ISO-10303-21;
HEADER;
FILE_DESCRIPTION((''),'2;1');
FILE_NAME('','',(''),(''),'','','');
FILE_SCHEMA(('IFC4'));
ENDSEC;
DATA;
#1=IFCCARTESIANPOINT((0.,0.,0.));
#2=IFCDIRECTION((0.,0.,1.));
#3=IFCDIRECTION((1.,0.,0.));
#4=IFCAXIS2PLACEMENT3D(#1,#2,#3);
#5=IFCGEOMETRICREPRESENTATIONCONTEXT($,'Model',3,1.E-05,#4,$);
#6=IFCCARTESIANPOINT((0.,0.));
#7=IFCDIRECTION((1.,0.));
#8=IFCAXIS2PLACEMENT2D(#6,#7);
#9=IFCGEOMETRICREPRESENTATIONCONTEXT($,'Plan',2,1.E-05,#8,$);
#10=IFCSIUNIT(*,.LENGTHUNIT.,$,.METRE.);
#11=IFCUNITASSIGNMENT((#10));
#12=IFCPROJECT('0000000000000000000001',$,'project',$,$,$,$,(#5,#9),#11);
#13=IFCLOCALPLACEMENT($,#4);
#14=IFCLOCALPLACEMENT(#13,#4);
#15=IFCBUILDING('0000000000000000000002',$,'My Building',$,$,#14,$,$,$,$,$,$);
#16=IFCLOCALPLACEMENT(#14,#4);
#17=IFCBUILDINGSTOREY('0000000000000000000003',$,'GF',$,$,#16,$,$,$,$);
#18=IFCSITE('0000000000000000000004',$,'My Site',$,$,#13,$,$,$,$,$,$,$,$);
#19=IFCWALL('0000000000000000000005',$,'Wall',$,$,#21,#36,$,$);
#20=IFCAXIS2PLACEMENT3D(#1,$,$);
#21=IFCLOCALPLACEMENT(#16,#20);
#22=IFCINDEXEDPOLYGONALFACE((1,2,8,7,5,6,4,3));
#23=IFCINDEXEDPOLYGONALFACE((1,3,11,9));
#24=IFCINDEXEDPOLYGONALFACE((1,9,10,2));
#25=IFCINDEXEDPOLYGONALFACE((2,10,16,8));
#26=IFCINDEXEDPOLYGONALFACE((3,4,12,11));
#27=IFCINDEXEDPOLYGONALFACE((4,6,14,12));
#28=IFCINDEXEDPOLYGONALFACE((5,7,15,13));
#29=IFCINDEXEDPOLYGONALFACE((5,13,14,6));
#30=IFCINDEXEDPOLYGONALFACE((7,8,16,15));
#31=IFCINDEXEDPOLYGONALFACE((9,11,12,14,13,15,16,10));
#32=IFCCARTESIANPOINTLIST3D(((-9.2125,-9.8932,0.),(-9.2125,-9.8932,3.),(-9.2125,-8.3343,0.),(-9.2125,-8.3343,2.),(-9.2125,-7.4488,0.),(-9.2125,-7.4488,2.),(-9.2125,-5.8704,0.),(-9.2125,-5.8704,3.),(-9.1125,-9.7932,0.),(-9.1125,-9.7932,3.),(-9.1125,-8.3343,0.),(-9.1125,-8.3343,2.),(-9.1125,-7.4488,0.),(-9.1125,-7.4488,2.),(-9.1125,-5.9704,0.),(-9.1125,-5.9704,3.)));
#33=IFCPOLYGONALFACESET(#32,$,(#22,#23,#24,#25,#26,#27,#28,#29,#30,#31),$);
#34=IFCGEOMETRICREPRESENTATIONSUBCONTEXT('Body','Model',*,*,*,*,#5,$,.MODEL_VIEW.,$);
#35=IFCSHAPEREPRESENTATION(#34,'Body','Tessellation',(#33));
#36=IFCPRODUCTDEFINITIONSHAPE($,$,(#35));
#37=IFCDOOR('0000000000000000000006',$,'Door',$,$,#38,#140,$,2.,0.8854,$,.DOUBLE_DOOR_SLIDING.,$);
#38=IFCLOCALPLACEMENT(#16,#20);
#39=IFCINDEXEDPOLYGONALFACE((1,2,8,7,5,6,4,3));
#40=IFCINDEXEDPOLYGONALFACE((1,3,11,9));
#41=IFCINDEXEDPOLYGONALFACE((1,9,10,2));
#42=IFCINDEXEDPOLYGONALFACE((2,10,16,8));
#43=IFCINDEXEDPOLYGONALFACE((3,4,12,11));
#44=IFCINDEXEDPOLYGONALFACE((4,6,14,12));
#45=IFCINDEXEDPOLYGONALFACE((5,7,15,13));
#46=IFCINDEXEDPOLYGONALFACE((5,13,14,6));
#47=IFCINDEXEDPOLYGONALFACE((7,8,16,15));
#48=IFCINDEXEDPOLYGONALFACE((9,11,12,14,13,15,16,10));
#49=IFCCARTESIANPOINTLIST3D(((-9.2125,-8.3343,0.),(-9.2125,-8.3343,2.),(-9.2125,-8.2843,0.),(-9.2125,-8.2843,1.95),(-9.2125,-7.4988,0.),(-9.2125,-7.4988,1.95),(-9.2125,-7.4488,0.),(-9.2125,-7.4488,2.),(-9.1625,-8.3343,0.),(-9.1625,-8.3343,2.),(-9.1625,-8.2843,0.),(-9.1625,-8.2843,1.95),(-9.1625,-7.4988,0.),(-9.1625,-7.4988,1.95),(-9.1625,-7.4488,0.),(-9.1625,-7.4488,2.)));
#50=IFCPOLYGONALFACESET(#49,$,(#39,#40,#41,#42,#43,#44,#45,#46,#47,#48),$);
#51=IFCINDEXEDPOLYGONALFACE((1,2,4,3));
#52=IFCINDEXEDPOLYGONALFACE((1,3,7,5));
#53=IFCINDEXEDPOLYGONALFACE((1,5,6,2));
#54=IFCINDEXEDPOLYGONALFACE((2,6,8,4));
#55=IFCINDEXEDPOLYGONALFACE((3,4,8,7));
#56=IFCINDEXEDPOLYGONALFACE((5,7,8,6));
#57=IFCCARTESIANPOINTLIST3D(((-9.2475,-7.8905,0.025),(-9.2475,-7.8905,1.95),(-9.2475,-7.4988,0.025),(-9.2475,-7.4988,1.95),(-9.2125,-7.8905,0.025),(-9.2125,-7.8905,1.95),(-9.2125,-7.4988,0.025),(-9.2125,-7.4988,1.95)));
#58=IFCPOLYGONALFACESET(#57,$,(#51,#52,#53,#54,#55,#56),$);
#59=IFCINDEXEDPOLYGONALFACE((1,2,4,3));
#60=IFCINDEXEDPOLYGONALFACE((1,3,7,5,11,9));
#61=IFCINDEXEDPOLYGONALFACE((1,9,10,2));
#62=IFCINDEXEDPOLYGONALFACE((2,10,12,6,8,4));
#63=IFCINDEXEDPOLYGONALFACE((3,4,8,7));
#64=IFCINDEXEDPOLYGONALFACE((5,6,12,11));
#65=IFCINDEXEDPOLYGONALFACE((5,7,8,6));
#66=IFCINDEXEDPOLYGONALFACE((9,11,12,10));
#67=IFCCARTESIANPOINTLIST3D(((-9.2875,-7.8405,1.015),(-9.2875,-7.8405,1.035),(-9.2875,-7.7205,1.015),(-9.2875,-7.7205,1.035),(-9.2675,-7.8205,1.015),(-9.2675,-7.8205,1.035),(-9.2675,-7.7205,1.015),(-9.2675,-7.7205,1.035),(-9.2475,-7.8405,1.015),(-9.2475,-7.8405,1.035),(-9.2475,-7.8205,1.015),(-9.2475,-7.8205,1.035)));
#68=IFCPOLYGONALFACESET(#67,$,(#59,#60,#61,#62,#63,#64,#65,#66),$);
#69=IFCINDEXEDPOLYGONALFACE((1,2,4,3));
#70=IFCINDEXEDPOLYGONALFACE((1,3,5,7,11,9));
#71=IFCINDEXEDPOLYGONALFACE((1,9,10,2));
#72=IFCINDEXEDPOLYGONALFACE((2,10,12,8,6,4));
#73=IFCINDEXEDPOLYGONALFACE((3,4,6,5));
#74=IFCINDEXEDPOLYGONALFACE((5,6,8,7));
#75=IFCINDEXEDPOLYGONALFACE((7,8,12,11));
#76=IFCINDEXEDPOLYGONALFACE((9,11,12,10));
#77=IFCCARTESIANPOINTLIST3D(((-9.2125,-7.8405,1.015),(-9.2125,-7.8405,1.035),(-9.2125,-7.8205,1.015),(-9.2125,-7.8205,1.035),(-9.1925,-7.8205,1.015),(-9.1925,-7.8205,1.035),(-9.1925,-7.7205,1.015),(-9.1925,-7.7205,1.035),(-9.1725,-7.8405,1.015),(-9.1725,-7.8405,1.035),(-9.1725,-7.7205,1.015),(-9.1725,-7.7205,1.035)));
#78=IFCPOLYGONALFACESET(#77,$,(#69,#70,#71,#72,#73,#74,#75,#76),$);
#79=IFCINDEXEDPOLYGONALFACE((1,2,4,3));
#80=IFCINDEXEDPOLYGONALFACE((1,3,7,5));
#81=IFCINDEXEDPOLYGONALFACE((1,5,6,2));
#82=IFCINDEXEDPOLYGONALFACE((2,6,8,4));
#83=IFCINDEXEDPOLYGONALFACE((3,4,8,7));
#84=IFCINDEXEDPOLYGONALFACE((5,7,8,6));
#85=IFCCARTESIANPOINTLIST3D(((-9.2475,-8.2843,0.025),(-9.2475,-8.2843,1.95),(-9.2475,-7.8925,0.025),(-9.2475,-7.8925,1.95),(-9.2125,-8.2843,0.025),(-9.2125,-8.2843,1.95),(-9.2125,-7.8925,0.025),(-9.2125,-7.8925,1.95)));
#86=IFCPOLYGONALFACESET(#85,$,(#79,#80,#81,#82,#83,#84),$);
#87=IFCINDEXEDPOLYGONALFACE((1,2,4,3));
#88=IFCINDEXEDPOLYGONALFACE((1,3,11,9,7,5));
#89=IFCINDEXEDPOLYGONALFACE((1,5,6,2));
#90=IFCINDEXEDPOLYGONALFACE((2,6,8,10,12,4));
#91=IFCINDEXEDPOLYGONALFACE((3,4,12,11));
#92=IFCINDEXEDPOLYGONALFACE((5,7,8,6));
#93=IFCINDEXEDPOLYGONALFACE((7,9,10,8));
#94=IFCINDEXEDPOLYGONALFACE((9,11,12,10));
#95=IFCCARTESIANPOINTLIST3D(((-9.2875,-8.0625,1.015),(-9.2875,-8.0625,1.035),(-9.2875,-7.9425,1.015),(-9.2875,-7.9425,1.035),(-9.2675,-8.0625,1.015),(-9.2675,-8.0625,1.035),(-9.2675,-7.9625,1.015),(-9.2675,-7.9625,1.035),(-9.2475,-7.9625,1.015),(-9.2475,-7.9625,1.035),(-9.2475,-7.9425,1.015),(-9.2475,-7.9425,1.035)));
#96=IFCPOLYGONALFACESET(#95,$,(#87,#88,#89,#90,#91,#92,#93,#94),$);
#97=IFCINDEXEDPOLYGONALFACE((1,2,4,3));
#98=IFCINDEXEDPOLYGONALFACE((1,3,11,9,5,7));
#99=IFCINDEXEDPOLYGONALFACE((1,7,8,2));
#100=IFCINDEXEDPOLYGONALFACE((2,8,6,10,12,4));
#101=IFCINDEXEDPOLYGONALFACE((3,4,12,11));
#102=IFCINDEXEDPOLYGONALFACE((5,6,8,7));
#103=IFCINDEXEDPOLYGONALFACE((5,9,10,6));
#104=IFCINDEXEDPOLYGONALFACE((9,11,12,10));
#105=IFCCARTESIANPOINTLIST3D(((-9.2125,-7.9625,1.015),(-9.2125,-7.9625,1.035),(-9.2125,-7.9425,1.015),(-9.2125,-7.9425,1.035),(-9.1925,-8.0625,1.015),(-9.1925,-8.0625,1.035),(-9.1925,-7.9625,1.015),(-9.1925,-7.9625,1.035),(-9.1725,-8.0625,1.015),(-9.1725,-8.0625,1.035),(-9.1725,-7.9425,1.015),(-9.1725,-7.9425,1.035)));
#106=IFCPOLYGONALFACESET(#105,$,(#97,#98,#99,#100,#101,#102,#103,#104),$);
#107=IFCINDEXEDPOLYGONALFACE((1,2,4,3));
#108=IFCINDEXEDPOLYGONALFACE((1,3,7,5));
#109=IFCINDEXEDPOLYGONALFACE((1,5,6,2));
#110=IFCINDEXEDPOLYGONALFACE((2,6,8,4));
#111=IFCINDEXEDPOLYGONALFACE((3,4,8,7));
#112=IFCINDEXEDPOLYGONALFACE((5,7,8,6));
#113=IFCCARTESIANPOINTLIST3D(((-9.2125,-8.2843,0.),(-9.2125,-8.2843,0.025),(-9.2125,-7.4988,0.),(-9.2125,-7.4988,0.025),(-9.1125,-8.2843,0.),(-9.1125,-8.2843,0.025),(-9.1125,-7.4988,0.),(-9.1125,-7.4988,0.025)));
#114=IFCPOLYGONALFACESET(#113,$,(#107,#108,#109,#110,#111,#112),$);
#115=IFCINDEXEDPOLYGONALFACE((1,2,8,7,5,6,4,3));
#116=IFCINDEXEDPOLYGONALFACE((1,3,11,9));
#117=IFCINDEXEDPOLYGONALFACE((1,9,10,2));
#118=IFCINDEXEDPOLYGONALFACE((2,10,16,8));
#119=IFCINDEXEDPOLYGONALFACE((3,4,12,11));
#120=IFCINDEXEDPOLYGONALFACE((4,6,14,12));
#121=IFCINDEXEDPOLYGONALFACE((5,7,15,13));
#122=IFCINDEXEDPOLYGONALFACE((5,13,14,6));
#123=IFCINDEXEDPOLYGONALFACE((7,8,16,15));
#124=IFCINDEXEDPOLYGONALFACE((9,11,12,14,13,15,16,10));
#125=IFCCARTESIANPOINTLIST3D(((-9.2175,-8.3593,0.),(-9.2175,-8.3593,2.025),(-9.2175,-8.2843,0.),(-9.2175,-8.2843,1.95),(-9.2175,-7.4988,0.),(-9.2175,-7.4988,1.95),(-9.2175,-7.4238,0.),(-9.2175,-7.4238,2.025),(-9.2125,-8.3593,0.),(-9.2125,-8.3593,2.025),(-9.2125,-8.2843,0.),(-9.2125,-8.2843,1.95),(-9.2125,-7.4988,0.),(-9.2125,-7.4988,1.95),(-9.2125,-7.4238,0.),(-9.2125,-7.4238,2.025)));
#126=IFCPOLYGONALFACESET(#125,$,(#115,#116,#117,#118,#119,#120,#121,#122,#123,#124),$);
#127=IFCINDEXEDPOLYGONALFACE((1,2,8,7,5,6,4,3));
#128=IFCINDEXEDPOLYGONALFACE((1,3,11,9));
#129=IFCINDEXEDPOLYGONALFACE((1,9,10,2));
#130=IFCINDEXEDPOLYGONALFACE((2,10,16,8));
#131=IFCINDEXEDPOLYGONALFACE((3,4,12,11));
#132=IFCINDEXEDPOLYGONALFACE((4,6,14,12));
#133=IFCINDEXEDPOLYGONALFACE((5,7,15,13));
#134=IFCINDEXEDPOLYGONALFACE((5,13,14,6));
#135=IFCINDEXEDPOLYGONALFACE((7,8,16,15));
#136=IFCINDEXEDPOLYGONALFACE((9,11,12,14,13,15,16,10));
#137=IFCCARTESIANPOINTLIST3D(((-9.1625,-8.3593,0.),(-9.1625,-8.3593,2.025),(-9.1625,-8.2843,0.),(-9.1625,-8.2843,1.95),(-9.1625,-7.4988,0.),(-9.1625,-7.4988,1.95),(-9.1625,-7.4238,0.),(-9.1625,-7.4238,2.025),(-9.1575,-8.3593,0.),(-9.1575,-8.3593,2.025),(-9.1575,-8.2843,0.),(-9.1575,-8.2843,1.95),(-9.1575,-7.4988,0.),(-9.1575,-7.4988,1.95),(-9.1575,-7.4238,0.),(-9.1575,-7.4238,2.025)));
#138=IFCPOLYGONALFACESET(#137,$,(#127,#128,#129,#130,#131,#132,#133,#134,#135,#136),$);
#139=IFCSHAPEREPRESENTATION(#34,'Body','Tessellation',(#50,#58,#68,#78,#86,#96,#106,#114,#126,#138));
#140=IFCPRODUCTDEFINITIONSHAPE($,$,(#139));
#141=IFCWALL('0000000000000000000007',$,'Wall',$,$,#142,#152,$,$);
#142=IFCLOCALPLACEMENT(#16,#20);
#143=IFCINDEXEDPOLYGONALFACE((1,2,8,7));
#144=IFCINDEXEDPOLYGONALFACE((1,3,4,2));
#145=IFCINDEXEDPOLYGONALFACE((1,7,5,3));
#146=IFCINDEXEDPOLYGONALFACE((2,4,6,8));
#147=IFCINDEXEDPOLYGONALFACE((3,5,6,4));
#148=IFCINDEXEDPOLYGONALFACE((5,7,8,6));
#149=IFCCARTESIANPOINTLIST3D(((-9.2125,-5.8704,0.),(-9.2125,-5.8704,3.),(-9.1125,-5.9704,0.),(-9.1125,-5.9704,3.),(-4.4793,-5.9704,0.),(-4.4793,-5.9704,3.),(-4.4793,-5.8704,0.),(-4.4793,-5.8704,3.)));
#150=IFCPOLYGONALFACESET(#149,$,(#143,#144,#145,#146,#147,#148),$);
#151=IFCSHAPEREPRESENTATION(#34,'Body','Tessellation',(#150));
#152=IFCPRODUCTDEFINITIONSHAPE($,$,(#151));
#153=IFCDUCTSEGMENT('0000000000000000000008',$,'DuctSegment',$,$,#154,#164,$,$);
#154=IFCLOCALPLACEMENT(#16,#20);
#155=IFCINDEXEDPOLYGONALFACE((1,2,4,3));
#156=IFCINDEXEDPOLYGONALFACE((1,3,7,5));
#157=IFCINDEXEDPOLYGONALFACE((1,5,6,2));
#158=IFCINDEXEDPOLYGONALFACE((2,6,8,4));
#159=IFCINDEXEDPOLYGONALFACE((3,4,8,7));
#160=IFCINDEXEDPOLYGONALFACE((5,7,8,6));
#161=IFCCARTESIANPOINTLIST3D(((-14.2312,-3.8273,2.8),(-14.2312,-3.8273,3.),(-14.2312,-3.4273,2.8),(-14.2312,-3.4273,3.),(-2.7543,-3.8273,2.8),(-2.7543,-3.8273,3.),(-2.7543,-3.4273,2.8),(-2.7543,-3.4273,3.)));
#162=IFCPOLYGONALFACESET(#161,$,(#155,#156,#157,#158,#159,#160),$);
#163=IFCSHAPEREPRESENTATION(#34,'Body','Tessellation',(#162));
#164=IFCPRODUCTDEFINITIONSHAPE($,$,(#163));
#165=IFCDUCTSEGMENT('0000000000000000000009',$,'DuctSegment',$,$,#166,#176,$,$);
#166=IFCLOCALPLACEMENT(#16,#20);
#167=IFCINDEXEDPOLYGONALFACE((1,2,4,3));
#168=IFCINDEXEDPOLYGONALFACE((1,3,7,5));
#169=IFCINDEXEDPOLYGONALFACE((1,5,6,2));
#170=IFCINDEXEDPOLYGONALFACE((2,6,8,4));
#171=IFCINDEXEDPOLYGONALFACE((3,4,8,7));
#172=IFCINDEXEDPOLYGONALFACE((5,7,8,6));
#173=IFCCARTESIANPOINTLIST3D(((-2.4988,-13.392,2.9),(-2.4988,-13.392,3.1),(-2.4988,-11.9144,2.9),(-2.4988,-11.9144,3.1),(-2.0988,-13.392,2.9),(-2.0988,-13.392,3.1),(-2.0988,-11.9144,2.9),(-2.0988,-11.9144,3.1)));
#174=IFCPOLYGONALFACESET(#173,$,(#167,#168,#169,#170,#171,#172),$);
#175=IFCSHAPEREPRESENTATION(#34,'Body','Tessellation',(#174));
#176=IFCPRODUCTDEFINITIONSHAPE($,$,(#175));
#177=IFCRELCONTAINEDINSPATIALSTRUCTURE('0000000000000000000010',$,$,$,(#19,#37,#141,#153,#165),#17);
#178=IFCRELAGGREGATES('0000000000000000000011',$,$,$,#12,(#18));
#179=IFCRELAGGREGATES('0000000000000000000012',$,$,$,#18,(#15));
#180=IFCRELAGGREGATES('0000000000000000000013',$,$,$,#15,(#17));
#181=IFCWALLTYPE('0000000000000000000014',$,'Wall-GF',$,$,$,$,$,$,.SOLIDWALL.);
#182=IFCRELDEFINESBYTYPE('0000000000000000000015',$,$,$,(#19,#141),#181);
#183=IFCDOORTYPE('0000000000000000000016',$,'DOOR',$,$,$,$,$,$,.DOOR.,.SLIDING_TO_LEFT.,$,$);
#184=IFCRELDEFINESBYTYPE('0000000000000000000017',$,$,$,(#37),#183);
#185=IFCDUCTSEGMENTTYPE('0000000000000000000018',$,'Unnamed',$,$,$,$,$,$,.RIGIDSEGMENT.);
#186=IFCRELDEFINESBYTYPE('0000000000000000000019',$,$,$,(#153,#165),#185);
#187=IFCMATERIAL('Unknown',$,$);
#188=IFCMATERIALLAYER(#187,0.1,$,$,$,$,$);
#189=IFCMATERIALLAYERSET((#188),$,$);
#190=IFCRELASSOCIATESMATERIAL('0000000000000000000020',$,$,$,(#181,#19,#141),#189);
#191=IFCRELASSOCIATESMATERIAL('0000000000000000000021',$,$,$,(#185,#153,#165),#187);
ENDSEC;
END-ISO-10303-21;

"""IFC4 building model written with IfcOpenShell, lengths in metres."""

from ifc_helpers import new_model, entity, si_unit, frame, origin_with_axes, origin_2d_with_axis, place, context, subcontext, project, spatial, line, indexed_curve, rectangle, outline, extrude, shape, source, transform, mapped, material, layer, layer_set, layer_usage, material_profile, profile_set, profile_usage, type_object, type_shapes, element, fill, save


model = new_model("IFC4")

# Units and contexts
model_context = context("Model", 3, precision=1e-05, world=origin_with_axes())
plan_context = context("Plan", 2, precision=1e-05, world=origin_2d_with_axis())
body_context_1 = subcontext(model_context, "Body", "Model", "MODEL_VIEW")
body_context_2 = subcontext(plan_context, "Body", "Plan", "PLAN_VIEW")
ifc_project = project(units=[si_unit("LENGTHUNIT", "METRE")], contexts=[model_context, plan_context])

# Site, building, storey
site_placement = place(None, origin_with_axes())
site = spatial("IfcSite", under=ifc_project, at=site_placement, Name="My Site")
building_placement = place(site_placement, origin_with_axes())
building = spatial("IfcBuilding", under=site, at=building_placement, Name="My Building")
storey_placement = place(building_placement, origin_with_axes())
storey = spatial("IfcBuildingStorey", under=building, at=storey_placement, Name="GF")

# Shared definitions
ifc_material = material(Name="Unknown")

# Shared definitions
ifc_layer_1 = layer(ifc_material, 0.1)
ifc_layer_set_1 = layer_set([ifc_layer_1])
wall_type = type_object("IfcWallType", Name="Wall-GF", PredefinedType="SOLIDWALL", material=ifc_layer_set_1)
shared_shape_1 = source(origin_with_axes(), body_context_1, "Body", "SweptSolid", [
    extrude(outline(indexed_curve([(0.0, 0.0), (0.8854, 0.0), (0.8854, 2.0), (0.0, 2.0)], segments=[line(1, 2, 3, 4, 1)])), frame((0.0, -0.6, 0.0), z_axis=(0.0, -1.0, 0.0), x_axis=(1.0, 0.0, 0.0)), (0.0, 0.0, -1.0), 1.2),
])
door_type = type_object("IfcDoorType", Name="DOOR", OperationType="SLIDING_TO_LEFT", PredefinedType="DOOR")
shared_shape_2 = source(origin_with_axes(), body_context_1, "Body", "SweptSolid", [
    extrude(outline(indexed_curve([(0.0, 0.0), (0.0, 2.0), (0.8854, 2.0), (0.8854, 0.0), (0.8354, 0.0), (0.8354, 1.95), (0.05, 1.95), (0.05, 0.0)], segments=[line(1, 2, 3, 4, 5, 6, 7, 8, 1)])), frame((0.0, 0.0, 0.0), z_axis=(0.0, -1.0, 0.0), x_axis=(1.0, 0.0, 0.0)), (0.0, 0.0, -1.0), 0.05),
    extrude(outline(indexed_curve([(0.0, 0.0), (0.3917, 0.0), (0.3917, 0.035), (0.0, 0.035)], segments=[line(1, 2, 3, 4, 1)])), frame((0.05, -0.035, 0.025), z_axis=(0.0, 0.0, 1.0), x_axis=(1.0, 0.0, 0.0)), (0.0, 0.0, 1.0), 1.925),
    extrude(outline(indexed_curve([(0.0, 0.0), (0.0, -0.04), (-0.12, -0.04), (-0.12, -0.02), (-0.02, -0.02), (-0.02, 0.0)], segments=[line(1, 2, 3, 4, 5, 6, 1)])), frame((0.3917, -0.035, 1.015), z_axis=(0.0, 0.0, 1.0), x_axis=(1.0, 0.0, 0.0)), (0.0, 0.0, 1.0), 0.02),
    extrude(outline(indexed_curve([(0.0, 0.0), (0.0, 0.04), (-0.12, 0.04), (-0.12, 0.02), (-0.02, 0.02), (-0.02, 0.0)], segments=[line(1, 2, 3, 4, 5, 6, 1)])), frame((0.3917, 0.0, 1.015), z_axis=(0.0, 0.0, 1.0), x_axis=(1.0, 0.0, 0.0)), (0.0, 0.0, 1.0), 0.02),
    extrude(outline(indexed_curve([(0.0, 0.0), (-0.3917, 0.0), (-0.3917, 0.035), (0.0, 0.035)], segments=[line(1, 2, 3, 4, 1)])), frame((0.8354, -0.035, 0.025), z_axis=(0.0, 0.0, 1.0), x_axis=(1.0, 0.0, 0.0)), (0.0, 0.0, 1.0), 1.925),
    extrude(outline(indexed_curve([(0.0, 0.0), (0.0, -0.04), (0.12, -0.04), (0.12, -0.02), (0.02, -0.02), (0.02, 0.0)], segments=[line(1, 2, 3, 4, 5, 6, 1)])), frame((0.4937, -0.035, 1.015), z_axis=(0.0, 0.0, 1.0), x_axis=(1.0, 0.0, 0.0)), (0.0, 0.0, 1.0), 0.02),
    extrude(outline(indexed_curve([(0.0, 0.0), (0.0, 0.04), (0.12, 0.04), (0.12, 0.02), (0.02, 0.02), (0.02, 0.0)], segments=[line(1, 2, 3, 4, 5, 6, 1)])), frame((0.4937, 0.0, 1.015), z_axis=(0.0, 0.0, 1.0), x_axis=(1.0, 0.0, 0.0)), (0.0, 0.0, 1.0), 0.02),
    extrude(outline(indexed_curve([(0.0, 0.0), (0.7854, 0.0), (0.7854, 0.1), (0.0, 0.1)], segments=[line(1, 2, 3, 4, 1)])), frame((0.05, 0.0, 0.0), z_axis=(0.0, 0.0, 1.0), x_axis=(1.0, 0.0, 0.0)), (0.0, 0.0, 1.0), 0.025),
    extrude(outline(indexed_curve([(0.0, 0.0), (0.0, 2.025), (0.9354, 2.025), (0.9354, 0.0), (0.8604, 0.0), (0.8604, 1.95), (0.075, 1.95), (0.075, 0.0)], segments=[line(1, 2, 3, 4, 5, 6, 7, 8, 1)])), frame((-0.025, -0.005, 0.0), z_axis=(0.0, -1.0, 0.0), x_axis=(1.0, 0.0, 0.0)), (0.0, 0.0, -1.0), 0.005),
    extrude(outline(indexed_curve([(0.0, 0.0), (0.0, 2.025), (0.9354, 2.025), (0.9354, 0.0), (0.8604, 0.0), (0.8604, 1.95), (0.075, 1.95), (0.075, 0.0)], segments=[line(1, 2, 3, 4, 5, 6, 7, 8, 1)])), frame((-0.025, 0.05, 0.0), z_axis=(0.0, -1.0, 0.0), x_axis=(1.0, 0.0, 0.0)), (0.0, 0.0, -1.0), 0.005),
])
shared_shape_3 = source(origin_with_axes(), body_context_2, "Body", "Curve2D", [
    entity("IfcIndexedPolyCurve", entity("IfcCartesianPointList2D", [[0.0, 0.0], [0.05, 0.0], [0.05, 0.05], [0.0, 0.05]]), [entity("IfcLineIndex", [1, 2, 3, 4, 1])]),
    entity("IfcIndexedPolyCurve", entity("IfcCartesianPointList2D", [[0.8854, 0.0], [0.8354, 0.0], [0.8354, 0.05], [0.8854, 0.05]]), [entity("IfcLineIndex", [1, 2, 3, 4, 1])]),
    entity("IfcIndexedPolyCurve", entity("IfcCartesianPointList2D", [[-0.1464, -0.035], [0.2464, -0.035], [0.2464, 0.0], [-0.1464, 0.0]]), [entity("IfcLineIndex", [1, 2, 3, 4, 1])]),
    entity("IfcIndexedPolyCurve", entity("IfcCartesianPointList2D", [[1.0318, -0.035], [0.6391, -0.035], [0.6391, 0.0], [1.0318, 0.0]]), [entity("IfcLineIndex", [1, 2, 3, 4, 1])]),
])
type_shapes(door_type, [shared_shape_2, shared_shape_3])

# Wall, opening, door
ifc_layer_usage_1 = layer_usage(ifc_layer_set_1, "AXIS2", "POSITIVE", 0.0)
wall_1_placement = place(storey_placement, frame((-9.1125, -9.7932, 0.0), z_axis=(0.0, 0.0, 1.0), x_axis=(0.0, 1.0, 0.0)))
wall_1 = element("IfcWall", 1, at=wall_1_placement, inside=storey, type_object=wall_type, material=ifc_layer_usage_1, Name="Wall", context=body_context_1, shape_type="SweptSolid", body=[
    extrude(outline(indexed_curve([(0.0, 0.0), (-0.1, 0.1), (3.9228, 0.1), (3.8228, 0.0)], segments=[line(1, 2, 3, 4, 1)])), origin_with_axes(), (0.0, 0.0, 1.0), 3.0),
])
opening_1_placement = place(wall_1_placement, frame((2.3443, 0.1, 0.0), z_axis=(0.0, 0.0, 1.0), x_axis=(-1.0, 0.0, 0.0)))
opening_1 = element("IfcOpeningElement", 2, at=opening_1_placement, cuts=wall_1, PredefinedType="OPENING", context=body_context_1, shape_type="MappedRepresentation", body=[
    mapped(shared_shape_1, transform((0.0, 0.0, 0.0), x_axis=(1.0, 0.0, 0.0), y_axis=(0.0, 1.0, 0.0), z_axis=(0.0, 0.0, 1.0), scale=1.0)),
])
door_1_placement = place(opening_1_placement, frame((0.0, 0.0, 0.0), z_axis=(0.0, 0.0, 1.0), x_axis=(1.0, 0.0, 0.0)))
door_1 = element("IfcDoor", 3, at=door_1_placement, inside=storey, type_object=door_type, Name="Door", OperationType="DOUBLE_DOOR_SLIDING", OverallHeight=2.0, OverallWidth=0.8854, shapes=[
    shape(body_context_1, "Body", "MappedRepresentation", [mapped(shared_shape_2, transform((0.0, 0.0, 0.0), x_axis=(1.0, 0.0, 0.0), y_axis=(0.0, 1.0, 0.0), z_axis=(0.0, 0.0, 1.0), scale=1.0))]),
    shape(body_context_2, "Body", "MappedRepresentation", [mapped(shared_shape_3, transform((0.0, 0.0, 0.0), x_axis=(1.0, 0.0, 0.0), y_axis=(0.0, 1.0, 0.0), z_axis=(0.0, 0.0, 1.0), scale=1.0))]),
])
fill(opening_1, door_1)

# Wall
ifc_layer_usage_2 = layer_usage(ifc_layer_set_1, "AXIS2", "POSITIVE", 0.0)
wall_2_placement = place(storey_placement, frame((-9.1125, -5.9704, 0.0), z_axis=(0.0, 0.0, 1.0), x_axis=(1.0, 0.0, 0.0)))
element("IfcWall", 4, at=wall_2_placement, inside=storey, type_object=wall_type, material=ifc_layer_usage_2, Name="Wall", context=body_context_1, shape_type="SweptSolid", body=[
    extrude(outline(indexed_curve([(0.0, 0.0), (-0.1, 0.1), (4.6332, 0.1), (4.6332, 0.0)], segments=[line(1, 2, 3, 4, 1)])), origin_with_axes(), (0.0, 0.0, 1.0), 3.0),
])

# Duct segments
ifc_material_profile_1 = material_profile(ifc_material, rectangle(XDim=0.4, YDim=0.2))
ifc_profile_set_1 = profile_set([ifc_material_profile_1])
ifc_profile_usage_1 = profile_usage(ifc_profile_set_1, cardinal=5)
duct_segment_type = type_object("IfcDuctSegmentType", Name="Unnamed", PredefinedType="RIGIDSEGMENT", material=ifc_profile_set_1)
duct_segment_1_placement = place(storey_placement, frame((-2.7543, -3.6273, 2.9), z_axis=(-1.0, 0.0, 0.0), x_axis=(0.0, -1.0, 0.0)))
element("IfcDuctSegment", 5, at=duct_segment_1_placement, inside=storey, type_object=duct_segment_type, material=ifc_profile_usage_1, Name="DuctSegment", context=body_context_1, shape_type="SweptSolid", body=[
    extrude(rectangle(XDim=0.4, YDim=0.2), origin_with_axes(), (0.0, 0.0, 1.0), 11.4769),
])
ifc_profile_usage_2 = profile_usage(ifc_profile_set_1, cardinal=5)
duct_segment_2_placement = place(storey_placement, frame((-2.2988, -11.9144, 3.0), z_axis=(0.0, -1.0, 0.0), x_axis=(1.0, 0.0, 0.0)))
element("IfcDuctSegment", 6, at=duct_segment_2_placement, inside=storey, type_object=duct_segment_type, material=ifc_profile_usage_2, Name="DuctSegment", context=body_context_1, shape_type="SweptSolid", body=[
    extrude(rectangle(XDim=0.4, YDim=0.2), origin_with_axes(), (0.0, 0.0, 1.0), 1.4777),
])

save(model, "model.ifc")
